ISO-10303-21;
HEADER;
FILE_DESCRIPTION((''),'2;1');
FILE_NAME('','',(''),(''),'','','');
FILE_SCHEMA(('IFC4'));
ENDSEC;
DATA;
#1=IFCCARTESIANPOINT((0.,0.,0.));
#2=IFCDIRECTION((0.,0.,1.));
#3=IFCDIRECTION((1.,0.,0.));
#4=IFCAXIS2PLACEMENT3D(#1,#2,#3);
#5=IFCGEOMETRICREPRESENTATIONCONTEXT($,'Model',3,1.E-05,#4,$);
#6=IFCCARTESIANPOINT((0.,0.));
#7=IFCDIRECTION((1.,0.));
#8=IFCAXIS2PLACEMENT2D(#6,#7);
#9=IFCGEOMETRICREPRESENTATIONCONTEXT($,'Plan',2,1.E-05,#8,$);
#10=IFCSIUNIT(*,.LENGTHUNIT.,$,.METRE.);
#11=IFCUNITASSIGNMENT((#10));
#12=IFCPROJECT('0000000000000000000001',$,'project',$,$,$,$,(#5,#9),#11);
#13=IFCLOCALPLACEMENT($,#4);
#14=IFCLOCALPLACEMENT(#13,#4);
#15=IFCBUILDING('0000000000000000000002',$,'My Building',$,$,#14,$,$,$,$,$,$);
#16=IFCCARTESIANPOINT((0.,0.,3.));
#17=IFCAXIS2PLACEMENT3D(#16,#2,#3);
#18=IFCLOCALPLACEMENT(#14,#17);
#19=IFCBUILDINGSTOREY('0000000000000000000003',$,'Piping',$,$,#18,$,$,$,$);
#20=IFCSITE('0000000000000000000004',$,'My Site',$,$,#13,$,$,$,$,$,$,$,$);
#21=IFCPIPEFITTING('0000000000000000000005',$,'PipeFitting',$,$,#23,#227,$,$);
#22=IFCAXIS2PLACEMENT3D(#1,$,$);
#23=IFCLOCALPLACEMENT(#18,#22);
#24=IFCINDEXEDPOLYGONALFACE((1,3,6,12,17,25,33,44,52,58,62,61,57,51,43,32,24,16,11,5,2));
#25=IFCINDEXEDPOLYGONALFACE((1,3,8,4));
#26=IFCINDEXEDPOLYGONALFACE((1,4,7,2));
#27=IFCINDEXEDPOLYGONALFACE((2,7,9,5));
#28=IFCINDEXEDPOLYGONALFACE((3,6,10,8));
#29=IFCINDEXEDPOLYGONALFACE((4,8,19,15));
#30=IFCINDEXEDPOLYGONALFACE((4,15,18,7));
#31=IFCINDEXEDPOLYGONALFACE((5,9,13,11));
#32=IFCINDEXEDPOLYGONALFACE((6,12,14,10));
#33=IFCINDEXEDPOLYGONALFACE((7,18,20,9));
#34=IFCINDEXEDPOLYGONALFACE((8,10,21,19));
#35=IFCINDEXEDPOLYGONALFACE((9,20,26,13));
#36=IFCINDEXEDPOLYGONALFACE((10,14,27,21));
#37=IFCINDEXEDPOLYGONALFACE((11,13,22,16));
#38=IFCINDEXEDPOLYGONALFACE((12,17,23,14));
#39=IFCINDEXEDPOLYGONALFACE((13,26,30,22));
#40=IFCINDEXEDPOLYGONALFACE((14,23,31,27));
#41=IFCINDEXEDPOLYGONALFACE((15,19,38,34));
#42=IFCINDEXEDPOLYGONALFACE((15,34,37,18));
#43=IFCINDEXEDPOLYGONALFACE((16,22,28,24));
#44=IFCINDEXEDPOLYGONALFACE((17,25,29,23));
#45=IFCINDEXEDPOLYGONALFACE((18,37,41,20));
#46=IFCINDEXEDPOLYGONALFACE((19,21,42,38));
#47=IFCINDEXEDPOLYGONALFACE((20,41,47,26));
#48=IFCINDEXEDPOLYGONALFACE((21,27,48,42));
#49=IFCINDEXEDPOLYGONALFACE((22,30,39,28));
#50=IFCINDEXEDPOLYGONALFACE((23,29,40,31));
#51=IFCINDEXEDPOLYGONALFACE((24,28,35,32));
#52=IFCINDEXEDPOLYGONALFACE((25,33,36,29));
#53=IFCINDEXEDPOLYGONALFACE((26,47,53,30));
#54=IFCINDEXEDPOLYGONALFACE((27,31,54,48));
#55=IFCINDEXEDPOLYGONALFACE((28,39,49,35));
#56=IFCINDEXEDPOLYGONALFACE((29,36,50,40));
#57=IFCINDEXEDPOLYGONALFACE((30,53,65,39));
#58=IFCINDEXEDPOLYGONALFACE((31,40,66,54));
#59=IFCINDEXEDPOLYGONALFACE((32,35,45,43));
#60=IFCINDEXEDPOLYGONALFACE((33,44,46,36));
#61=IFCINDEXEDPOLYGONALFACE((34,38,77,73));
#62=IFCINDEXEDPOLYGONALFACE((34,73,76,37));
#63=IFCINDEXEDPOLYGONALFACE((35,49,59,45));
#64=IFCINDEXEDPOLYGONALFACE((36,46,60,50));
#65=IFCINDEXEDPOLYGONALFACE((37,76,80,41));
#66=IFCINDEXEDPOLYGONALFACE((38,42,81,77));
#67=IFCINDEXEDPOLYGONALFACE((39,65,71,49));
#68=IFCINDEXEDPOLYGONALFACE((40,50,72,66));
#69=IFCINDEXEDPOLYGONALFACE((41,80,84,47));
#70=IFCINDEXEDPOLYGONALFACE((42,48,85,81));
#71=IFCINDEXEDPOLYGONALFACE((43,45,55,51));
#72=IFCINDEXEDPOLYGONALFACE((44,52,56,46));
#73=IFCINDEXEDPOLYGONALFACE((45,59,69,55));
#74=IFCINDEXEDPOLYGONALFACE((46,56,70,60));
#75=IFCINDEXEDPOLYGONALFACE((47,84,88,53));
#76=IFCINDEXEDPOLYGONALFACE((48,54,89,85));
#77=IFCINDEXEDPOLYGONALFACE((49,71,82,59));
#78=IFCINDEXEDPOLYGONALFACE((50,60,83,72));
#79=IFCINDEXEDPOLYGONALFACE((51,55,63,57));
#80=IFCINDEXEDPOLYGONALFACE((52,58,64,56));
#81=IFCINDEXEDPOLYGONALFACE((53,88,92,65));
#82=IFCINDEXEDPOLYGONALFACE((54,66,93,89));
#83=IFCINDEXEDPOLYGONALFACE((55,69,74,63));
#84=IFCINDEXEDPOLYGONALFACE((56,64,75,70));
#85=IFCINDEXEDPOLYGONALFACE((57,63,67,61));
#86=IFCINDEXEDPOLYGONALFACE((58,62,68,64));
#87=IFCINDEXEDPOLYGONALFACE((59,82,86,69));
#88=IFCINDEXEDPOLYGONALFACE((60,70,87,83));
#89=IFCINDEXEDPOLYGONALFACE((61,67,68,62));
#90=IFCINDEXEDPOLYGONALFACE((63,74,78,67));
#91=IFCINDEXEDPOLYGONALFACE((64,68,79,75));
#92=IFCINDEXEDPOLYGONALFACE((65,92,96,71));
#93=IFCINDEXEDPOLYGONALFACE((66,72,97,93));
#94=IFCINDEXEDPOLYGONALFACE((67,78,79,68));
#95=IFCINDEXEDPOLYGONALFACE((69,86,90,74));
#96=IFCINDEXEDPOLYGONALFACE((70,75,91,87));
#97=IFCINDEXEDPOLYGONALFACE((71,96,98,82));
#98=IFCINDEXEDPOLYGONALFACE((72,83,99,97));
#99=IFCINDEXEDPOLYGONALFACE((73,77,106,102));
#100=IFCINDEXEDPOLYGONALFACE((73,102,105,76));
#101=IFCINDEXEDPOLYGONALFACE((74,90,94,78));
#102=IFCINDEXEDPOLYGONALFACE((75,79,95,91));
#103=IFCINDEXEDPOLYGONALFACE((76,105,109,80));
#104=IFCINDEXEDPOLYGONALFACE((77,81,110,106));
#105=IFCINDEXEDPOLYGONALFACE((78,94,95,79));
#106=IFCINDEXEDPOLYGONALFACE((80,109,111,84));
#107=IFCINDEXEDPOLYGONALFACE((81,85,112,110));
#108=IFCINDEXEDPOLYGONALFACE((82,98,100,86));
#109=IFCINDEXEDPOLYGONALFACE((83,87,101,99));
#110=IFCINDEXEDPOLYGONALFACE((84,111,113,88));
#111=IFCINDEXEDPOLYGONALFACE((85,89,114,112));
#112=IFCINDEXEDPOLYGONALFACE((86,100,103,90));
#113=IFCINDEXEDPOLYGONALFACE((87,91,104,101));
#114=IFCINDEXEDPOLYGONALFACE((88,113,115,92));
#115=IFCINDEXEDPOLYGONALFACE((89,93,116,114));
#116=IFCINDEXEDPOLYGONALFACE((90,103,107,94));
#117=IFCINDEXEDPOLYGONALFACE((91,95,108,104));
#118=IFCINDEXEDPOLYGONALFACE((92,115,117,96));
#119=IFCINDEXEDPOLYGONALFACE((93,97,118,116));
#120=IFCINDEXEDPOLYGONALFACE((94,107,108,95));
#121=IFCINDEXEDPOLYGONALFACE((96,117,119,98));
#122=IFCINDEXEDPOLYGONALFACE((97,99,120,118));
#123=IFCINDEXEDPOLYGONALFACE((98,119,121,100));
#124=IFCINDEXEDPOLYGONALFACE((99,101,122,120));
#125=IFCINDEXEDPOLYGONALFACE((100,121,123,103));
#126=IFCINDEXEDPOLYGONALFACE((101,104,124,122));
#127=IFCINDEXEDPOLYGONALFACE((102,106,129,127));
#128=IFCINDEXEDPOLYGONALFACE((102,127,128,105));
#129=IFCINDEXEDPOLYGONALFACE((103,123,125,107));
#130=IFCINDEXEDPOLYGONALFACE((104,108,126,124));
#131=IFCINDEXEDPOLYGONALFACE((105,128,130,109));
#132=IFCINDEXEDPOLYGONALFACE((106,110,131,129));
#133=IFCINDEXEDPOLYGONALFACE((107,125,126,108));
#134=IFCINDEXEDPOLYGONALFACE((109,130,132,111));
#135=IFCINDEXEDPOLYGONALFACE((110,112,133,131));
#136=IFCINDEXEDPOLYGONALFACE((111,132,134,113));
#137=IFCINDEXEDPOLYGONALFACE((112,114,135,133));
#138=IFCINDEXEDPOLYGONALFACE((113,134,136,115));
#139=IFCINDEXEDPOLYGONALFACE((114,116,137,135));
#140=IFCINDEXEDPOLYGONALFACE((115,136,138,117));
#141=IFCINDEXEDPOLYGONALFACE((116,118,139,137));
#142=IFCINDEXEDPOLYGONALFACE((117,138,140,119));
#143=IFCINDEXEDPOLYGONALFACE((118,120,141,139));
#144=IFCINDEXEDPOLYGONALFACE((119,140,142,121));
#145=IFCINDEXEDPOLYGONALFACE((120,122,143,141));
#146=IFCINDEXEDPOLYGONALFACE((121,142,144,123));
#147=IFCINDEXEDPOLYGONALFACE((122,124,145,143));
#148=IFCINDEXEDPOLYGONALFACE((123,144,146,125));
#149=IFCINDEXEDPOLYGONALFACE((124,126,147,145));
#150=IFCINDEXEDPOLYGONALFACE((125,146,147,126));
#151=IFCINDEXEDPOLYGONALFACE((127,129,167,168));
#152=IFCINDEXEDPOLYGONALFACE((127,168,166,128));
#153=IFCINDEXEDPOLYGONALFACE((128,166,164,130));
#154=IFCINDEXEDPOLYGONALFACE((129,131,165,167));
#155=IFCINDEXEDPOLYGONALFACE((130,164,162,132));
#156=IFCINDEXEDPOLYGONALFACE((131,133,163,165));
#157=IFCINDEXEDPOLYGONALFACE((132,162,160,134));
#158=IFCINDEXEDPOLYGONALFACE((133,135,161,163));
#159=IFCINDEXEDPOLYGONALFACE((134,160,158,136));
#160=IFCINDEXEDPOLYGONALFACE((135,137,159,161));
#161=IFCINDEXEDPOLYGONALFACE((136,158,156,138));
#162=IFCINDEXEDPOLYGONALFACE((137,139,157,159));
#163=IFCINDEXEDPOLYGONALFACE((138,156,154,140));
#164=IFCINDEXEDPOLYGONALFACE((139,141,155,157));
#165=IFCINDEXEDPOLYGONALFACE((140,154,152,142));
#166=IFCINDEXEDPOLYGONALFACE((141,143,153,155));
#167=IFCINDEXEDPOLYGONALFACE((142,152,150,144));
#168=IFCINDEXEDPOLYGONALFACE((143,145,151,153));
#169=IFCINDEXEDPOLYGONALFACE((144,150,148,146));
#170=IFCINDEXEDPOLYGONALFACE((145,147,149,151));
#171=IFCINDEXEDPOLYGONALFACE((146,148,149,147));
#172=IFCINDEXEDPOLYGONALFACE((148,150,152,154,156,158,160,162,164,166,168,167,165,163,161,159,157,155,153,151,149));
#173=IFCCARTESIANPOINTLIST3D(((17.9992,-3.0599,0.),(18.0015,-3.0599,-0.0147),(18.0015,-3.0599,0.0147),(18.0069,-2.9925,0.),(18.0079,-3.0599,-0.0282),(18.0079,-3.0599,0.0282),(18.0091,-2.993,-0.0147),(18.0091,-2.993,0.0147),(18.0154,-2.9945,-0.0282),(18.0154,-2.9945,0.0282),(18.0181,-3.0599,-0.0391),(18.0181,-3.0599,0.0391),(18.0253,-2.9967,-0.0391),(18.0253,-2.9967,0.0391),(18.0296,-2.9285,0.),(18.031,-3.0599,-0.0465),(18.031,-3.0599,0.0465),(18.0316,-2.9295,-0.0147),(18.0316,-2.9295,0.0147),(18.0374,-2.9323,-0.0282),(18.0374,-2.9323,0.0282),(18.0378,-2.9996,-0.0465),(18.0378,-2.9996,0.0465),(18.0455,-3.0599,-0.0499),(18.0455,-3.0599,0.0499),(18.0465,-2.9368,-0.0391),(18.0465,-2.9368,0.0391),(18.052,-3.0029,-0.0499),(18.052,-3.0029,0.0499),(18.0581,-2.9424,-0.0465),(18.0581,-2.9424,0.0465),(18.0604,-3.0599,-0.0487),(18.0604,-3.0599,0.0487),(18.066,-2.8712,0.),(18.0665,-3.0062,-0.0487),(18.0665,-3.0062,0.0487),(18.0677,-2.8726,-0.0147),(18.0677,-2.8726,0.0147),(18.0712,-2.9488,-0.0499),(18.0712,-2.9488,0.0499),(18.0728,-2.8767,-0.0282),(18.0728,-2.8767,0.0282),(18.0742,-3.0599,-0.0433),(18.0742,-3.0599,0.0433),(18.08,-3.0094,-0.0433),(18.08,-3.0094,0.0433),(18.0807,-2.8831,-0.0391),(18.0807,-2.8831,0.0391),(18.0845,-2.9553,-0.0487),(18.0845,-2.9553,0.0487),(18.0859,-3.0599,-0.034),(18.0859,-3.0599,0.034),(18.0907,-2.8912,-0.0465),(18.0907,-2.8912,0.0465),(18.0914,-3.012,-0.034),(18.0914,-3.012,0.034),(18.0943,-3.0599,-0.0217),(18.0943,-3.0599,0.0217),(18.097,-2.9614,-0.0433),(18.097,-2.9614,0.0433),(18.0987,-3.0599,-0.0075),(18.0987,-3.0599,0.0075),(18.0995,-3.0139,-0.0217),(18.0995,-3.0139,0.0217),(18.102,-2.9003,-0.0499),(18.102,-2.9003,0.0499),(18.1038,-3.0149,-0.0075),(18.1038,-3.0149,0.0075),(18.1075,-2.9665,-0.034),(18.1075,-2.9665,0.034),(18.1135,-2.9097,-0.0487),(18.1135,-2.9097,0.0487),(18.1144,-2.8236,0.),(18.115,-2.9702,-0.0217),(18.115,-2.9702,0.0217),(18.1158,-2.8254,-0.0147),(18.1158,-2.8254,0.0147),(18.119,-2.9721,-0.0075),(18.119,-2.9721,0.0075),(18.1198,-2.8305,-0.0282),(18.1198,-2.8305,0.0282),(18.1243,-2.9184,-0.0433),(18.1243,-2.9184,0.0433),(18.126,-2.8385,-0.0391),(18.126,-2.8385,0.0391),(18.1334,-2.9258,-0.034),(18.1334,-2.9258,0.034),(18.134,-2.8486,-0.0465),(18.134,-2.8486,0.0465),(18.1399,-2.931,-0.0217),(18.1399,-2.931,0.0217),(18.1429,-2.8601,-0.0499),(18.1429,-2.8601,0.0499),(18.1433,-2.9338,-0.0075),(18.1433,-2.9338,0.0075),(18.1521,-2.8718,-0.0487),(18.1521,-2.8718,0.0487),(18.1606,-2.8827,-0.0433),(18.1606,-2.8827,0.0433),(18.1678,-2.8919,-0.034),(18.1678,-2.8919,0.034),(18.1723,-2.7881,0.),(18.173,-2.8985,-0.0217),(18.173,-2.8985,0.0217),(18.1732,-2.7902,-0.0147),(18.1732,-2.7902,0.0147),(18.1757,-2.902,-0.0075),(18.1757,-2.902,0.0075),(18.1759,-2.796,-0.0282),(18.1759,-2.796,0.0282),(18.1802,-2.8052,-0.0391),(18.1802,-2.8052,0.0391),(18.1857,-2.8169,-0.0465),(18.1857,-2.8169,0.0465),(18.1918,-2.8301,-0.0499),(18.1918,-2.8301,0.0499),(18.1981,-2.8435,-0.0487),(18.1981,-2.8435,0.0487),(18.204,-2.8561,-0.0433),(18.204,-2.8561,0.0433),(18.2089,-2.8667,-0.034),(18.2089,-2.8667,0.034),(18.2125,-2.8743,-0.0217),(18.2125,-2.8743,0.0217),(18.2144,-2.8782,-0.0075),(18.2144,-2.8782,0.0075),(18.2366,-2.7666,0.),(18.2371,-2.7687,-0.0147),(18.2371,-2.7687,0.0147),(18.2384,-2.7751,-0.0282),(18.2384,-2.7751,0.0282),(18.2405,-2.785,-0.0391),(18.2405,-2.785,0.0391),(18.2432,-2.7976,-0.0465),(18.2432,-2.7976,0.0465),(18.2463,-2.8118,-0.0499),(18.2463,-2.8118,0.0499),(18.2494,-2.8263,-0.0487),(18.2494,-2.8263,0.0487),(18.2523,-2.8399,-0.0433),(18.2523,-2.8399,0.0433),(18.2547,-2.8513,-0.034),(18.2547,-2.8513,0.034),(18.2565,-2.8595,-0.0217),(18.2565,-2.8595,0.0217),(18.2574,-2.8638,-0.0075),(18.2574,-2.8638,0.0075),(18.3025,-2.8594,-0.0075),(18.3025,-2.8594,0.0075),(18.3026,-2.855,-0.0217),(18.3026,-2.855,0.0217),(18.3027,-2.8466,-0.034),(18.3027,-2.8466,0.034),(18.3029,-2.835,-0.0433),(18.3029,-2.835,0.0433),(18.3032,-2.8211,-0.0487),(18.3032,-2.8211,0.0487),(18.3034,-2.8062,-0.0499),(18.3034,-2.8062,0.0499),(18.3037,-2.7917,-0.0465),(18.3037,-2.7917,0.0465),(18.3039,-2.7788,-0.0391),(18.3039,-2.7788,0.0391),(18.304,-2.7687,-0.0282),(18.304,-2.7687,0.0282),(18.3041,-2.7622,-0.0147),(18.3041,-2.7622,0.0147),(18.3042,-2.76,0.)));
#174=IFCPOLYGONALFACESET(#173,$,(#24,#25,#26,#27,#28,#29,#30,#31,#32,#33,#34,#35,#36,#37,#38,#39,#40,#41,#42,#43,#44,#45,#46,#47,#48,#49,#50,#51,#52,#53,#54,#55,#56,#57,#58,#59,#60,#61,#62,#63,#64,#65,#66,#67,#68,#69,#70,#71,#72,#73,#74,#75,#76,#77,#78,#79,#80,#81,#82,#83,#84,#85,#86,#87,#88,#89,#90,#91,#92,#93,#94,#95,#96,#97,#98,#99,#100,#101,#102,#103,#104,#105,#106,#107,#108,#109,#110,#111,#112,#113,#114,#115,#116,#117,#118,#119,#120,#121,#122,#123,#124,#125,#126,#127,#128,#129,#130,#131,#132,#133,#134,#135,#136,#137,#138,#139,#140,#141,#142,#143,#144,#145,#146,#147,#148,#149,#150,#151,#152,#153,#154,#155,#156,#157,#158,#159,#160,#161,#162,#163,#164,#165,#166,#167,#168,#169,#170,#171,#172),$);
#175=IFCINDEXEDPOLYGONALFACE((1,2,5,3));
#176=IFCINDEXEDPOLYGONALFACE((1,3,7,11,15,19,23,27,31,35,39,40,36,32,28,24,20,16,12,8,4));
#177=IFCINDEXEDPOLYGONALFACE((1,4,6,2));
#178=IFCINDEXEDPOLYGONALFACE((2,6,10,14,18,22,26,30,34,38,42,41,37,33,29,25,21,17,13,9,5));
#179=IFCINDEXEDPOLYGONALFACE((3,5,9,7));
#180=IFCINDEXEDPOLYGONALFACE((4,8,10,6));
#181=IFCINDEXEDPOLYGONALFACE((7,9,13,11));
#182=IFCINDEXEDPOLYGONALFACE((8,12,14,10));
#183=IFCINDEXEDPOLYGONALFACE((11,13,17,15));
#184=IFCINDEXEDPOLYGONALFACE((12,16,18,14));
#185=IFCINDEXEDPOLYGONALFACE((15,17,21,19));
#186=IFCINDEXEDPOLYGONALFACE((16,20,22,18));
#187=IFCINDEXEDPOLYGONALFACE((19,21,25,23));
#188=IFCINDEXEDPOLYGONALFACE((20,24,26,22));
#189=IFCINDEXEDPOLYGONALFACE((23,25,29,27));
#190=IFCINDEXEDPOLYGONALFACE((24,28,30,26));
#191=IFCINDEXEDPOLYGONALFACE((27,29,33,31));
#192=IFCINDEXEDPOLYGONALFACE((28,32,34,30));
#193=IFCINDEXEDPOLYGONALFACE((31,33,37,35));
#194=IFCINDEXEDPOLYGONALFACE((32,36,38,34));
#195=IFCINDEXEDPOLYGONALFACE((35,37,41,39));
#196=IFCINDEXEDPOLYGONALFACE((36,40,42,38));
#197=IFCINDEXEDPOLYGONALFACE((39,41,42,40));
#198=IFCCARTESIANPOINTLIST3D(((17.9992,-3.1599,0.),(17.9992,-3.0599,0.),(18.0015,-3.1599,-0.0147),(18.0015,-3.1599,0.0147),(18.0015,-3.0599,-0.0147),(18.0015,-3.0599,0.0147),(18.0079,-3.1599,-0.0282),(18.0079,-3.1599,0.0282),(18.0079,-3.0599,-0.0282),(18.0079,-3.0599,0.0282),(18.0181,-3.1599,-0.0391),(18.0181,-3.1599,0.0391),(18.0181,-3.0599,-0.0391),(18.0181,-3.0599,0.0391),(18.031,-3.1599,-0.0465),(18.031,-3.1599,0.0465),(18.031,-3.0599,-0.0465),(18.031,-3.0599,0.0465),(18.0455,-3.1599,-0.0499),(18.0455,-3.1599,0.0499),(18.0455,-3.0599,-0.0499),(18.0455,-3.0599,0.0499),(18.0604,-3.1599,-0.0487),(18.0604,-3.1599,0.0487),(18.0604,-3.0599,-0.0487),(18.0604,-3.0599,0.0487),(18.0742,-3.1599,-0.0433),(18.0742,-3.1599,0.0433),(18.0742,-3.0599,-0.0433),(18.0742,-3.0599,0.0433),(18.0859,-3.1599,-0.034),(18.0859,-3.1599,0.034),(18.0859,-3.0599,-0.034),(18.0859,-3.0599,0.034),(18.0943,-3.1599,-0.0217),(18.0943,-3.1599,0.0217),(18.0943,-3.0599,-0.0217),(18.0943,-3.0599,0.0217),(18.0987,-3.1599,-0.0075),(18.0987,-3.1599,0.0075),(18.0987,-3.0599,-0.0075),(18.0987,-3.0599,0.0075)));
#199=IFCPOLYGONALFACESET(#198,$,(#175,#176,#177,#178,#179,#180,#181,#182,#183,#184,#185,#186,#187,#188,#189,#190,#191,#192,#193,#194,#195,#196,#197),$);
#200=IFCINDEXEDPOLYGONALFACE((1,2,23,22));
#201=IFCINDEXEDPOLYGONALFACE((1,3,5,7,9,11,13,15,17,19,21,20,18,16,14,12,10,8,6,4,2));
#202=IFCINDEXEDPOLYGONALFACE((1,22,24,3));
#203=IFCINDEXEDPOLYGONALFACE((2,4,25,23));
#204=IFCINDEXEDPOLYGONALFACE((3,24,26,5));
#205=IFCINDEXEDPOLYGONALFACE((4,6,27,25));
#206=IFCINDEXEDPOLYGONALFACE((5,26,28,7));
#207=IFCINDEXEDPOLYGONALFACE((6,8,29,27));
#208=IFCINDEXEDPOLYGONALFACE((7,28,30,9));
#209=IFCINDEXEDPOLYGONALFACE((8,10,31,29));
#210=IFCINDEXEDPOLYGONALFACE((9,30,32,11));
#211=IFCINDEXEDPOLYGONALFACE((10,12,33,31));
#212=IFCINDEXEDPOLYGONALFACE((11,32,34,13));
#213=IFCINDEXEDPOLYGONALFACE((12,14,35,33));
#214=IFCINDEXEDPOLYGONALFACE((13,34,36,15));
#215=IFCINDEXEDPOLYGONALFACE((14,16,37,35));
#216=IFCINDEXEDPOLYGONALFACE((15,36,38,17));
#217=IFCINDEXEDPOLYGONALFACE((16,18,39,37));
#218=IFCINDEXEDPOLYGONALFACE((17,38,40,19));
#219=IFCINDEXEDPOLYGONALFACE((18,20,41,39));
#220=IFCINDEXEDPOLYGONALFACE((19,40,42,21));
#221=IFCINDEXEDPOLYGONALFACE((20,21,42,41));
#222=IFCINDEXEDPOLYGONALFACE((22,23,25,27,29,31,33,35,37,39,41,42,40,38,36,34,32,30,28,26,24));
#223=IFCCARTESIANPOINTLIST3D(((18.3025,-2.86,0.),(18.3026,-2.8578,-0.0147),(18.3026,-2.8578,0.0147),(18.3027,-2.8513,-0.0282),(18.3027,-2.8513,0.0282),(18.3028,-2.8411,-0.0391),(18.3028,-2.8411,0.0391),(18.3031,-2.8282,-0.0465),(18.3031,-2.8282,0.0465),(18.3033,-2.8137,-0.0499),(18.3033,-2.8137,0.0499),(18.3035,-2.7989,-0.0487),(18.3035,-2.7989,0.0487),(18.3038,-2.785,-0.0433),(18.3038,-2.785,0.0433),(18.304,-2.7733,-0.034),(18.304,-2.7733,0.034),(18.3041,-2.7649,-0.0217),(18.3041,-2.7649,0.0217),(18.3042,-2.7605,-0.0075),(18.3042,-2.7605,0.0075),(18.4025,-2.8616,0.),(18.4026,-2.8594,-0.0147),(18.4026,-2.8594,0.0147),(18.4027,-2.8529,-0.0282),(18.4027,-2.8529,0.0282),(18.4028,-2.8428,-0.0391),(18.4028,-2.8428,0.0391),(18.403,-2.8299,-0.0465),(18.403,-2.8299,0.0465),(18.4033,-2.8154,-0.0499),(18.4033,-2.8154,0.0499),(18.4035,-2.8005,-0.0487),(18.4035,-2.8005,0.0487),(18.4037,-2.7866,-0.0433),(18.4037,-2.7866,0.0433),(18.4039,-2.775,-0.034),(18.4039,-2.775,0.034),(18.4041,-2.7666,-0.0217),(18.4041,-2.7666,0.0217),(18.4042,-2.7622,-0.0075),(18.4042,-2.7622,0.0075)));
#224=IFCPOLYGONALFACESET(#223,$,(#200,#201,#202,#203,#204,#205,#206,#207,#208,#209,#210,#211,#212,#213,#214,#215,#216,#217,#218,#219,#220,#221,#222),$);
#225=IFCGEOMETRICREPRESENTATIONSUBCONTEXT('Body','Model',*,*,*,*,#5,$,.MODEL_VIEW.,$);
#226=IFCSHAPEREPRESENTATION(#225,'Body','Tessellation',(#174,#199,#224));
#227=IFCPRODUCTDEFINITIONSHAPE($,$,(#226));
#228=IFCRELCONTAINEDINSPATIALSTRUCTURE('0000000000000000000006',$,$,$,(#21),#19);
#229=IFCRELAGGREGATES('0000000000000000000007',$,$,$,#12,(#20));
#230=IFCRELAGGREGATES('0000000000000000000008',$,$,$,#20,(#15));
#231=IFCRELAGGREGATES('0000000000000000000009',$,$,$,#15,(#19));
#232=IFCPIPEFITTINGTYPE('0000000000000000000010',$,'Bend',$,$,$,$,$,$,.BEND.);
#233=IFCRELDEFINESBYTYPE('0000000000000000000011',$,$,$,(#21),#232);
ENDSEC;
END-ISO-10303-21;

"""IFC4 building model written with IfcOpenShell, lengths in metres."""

from ifc_helpers import new_model, entity, si_unit, frame, origin_with_axes, origin_2d_with_axis, place, context, subcontext, project, spatial, circle, extrude, source, transform, mapped, type_object, type_shapes, element, save


model = new_model("IFC4")

# Units and contexts
model_context = context("Model", 3, precision=1e-05, world=origin_with_axes())
plan_context = context("Plan", 2, precision=1e-05, world=origin_2d_with_axis())
body_context = subcontext(model_context, "Body", "Model", "MODEL_VIEW")
ifc_project = project(units=[si_unit("LENGTHUNIT", "METRE")], contexts=[model_context, plan_context])

# Site, building, storey
site_placement = place(None, origin_with_axes())
site = spatial("IfcSite", under=ifc_project, at=site_placement, Name="My Site")
building_placement = place(site_placement, origin_with_axes())
building = spatial("IfcBuilding", under=site, at=building_placement, Name="My Building")
storey_placement = place(building_placement, frame((0.0, 0.0, 3.0), z_axis=(0.0, 0.0, 1.0), x_axis=(1.0, 0.0, 0.0)))
storey = spatial("IfcBuildingStorey", under=building, at=storey_placement, Name="Piping")

# Pipe fitting
pipe_fitting_type_1 = type_object("IfcPipeFittingType", Name="Bend", PredefinedType="BEND")
shared_shape_1 = source(origin_with_axes(), body_context, "Body", "SolidModel", [
    entity("IfcSweptDiskSolid", entity("IfcIndexedPolyCurve", entity("IfcCartesianPointList3D", [[0.0, 0.0, 0.1], [-0.0747, 0.0, 0.2782], [-0.2541, 0.0, 0.35]]), [entity("IfcArcIndex", [1, 2, 3])]), 0.05),
    extrude(circle(Radius=0.05), origin_with_axes(), (0.0, 0.0, 1.0), 0.1),
    extrude(circle(Radius=0.05), frame((-0.2541, 0.0, 0.35), z_axis=(-0.999865, 0.0, -0.01644), x_axis=(0.01644, 0.0, -0.999865)), (0.0, 0.0, 1.0), 0.1),
])
type_shapes(pipe_fitting_type_1, [shared_shape_1])
pipe_fitting_1_placement = place(storey_placement, frame((18.0492, -3.1599, 0.0), z_axis=(0.0, 1.0, 0.0), x_axis=(-1.0, 0.0, 0.0)))
element("IfcPipeFitting", 1, at=pipe_fitting_1_placement, inside=storey, type_object=pipe_fitting_type_1, Name="PipeFitting", context=body_context, shape_type="MappedRepresentation", body=[
    mapped(shared_shape_1, transform((0.0, 0.0, 0.0), x_axis=(1.0, 0.0, 0.0), y_axis=(0.0, 1.0, 0.0), z_axis=(0.0, 0.0, 1.0), scale=1.0)),
])

save(model, "model.ifc")
